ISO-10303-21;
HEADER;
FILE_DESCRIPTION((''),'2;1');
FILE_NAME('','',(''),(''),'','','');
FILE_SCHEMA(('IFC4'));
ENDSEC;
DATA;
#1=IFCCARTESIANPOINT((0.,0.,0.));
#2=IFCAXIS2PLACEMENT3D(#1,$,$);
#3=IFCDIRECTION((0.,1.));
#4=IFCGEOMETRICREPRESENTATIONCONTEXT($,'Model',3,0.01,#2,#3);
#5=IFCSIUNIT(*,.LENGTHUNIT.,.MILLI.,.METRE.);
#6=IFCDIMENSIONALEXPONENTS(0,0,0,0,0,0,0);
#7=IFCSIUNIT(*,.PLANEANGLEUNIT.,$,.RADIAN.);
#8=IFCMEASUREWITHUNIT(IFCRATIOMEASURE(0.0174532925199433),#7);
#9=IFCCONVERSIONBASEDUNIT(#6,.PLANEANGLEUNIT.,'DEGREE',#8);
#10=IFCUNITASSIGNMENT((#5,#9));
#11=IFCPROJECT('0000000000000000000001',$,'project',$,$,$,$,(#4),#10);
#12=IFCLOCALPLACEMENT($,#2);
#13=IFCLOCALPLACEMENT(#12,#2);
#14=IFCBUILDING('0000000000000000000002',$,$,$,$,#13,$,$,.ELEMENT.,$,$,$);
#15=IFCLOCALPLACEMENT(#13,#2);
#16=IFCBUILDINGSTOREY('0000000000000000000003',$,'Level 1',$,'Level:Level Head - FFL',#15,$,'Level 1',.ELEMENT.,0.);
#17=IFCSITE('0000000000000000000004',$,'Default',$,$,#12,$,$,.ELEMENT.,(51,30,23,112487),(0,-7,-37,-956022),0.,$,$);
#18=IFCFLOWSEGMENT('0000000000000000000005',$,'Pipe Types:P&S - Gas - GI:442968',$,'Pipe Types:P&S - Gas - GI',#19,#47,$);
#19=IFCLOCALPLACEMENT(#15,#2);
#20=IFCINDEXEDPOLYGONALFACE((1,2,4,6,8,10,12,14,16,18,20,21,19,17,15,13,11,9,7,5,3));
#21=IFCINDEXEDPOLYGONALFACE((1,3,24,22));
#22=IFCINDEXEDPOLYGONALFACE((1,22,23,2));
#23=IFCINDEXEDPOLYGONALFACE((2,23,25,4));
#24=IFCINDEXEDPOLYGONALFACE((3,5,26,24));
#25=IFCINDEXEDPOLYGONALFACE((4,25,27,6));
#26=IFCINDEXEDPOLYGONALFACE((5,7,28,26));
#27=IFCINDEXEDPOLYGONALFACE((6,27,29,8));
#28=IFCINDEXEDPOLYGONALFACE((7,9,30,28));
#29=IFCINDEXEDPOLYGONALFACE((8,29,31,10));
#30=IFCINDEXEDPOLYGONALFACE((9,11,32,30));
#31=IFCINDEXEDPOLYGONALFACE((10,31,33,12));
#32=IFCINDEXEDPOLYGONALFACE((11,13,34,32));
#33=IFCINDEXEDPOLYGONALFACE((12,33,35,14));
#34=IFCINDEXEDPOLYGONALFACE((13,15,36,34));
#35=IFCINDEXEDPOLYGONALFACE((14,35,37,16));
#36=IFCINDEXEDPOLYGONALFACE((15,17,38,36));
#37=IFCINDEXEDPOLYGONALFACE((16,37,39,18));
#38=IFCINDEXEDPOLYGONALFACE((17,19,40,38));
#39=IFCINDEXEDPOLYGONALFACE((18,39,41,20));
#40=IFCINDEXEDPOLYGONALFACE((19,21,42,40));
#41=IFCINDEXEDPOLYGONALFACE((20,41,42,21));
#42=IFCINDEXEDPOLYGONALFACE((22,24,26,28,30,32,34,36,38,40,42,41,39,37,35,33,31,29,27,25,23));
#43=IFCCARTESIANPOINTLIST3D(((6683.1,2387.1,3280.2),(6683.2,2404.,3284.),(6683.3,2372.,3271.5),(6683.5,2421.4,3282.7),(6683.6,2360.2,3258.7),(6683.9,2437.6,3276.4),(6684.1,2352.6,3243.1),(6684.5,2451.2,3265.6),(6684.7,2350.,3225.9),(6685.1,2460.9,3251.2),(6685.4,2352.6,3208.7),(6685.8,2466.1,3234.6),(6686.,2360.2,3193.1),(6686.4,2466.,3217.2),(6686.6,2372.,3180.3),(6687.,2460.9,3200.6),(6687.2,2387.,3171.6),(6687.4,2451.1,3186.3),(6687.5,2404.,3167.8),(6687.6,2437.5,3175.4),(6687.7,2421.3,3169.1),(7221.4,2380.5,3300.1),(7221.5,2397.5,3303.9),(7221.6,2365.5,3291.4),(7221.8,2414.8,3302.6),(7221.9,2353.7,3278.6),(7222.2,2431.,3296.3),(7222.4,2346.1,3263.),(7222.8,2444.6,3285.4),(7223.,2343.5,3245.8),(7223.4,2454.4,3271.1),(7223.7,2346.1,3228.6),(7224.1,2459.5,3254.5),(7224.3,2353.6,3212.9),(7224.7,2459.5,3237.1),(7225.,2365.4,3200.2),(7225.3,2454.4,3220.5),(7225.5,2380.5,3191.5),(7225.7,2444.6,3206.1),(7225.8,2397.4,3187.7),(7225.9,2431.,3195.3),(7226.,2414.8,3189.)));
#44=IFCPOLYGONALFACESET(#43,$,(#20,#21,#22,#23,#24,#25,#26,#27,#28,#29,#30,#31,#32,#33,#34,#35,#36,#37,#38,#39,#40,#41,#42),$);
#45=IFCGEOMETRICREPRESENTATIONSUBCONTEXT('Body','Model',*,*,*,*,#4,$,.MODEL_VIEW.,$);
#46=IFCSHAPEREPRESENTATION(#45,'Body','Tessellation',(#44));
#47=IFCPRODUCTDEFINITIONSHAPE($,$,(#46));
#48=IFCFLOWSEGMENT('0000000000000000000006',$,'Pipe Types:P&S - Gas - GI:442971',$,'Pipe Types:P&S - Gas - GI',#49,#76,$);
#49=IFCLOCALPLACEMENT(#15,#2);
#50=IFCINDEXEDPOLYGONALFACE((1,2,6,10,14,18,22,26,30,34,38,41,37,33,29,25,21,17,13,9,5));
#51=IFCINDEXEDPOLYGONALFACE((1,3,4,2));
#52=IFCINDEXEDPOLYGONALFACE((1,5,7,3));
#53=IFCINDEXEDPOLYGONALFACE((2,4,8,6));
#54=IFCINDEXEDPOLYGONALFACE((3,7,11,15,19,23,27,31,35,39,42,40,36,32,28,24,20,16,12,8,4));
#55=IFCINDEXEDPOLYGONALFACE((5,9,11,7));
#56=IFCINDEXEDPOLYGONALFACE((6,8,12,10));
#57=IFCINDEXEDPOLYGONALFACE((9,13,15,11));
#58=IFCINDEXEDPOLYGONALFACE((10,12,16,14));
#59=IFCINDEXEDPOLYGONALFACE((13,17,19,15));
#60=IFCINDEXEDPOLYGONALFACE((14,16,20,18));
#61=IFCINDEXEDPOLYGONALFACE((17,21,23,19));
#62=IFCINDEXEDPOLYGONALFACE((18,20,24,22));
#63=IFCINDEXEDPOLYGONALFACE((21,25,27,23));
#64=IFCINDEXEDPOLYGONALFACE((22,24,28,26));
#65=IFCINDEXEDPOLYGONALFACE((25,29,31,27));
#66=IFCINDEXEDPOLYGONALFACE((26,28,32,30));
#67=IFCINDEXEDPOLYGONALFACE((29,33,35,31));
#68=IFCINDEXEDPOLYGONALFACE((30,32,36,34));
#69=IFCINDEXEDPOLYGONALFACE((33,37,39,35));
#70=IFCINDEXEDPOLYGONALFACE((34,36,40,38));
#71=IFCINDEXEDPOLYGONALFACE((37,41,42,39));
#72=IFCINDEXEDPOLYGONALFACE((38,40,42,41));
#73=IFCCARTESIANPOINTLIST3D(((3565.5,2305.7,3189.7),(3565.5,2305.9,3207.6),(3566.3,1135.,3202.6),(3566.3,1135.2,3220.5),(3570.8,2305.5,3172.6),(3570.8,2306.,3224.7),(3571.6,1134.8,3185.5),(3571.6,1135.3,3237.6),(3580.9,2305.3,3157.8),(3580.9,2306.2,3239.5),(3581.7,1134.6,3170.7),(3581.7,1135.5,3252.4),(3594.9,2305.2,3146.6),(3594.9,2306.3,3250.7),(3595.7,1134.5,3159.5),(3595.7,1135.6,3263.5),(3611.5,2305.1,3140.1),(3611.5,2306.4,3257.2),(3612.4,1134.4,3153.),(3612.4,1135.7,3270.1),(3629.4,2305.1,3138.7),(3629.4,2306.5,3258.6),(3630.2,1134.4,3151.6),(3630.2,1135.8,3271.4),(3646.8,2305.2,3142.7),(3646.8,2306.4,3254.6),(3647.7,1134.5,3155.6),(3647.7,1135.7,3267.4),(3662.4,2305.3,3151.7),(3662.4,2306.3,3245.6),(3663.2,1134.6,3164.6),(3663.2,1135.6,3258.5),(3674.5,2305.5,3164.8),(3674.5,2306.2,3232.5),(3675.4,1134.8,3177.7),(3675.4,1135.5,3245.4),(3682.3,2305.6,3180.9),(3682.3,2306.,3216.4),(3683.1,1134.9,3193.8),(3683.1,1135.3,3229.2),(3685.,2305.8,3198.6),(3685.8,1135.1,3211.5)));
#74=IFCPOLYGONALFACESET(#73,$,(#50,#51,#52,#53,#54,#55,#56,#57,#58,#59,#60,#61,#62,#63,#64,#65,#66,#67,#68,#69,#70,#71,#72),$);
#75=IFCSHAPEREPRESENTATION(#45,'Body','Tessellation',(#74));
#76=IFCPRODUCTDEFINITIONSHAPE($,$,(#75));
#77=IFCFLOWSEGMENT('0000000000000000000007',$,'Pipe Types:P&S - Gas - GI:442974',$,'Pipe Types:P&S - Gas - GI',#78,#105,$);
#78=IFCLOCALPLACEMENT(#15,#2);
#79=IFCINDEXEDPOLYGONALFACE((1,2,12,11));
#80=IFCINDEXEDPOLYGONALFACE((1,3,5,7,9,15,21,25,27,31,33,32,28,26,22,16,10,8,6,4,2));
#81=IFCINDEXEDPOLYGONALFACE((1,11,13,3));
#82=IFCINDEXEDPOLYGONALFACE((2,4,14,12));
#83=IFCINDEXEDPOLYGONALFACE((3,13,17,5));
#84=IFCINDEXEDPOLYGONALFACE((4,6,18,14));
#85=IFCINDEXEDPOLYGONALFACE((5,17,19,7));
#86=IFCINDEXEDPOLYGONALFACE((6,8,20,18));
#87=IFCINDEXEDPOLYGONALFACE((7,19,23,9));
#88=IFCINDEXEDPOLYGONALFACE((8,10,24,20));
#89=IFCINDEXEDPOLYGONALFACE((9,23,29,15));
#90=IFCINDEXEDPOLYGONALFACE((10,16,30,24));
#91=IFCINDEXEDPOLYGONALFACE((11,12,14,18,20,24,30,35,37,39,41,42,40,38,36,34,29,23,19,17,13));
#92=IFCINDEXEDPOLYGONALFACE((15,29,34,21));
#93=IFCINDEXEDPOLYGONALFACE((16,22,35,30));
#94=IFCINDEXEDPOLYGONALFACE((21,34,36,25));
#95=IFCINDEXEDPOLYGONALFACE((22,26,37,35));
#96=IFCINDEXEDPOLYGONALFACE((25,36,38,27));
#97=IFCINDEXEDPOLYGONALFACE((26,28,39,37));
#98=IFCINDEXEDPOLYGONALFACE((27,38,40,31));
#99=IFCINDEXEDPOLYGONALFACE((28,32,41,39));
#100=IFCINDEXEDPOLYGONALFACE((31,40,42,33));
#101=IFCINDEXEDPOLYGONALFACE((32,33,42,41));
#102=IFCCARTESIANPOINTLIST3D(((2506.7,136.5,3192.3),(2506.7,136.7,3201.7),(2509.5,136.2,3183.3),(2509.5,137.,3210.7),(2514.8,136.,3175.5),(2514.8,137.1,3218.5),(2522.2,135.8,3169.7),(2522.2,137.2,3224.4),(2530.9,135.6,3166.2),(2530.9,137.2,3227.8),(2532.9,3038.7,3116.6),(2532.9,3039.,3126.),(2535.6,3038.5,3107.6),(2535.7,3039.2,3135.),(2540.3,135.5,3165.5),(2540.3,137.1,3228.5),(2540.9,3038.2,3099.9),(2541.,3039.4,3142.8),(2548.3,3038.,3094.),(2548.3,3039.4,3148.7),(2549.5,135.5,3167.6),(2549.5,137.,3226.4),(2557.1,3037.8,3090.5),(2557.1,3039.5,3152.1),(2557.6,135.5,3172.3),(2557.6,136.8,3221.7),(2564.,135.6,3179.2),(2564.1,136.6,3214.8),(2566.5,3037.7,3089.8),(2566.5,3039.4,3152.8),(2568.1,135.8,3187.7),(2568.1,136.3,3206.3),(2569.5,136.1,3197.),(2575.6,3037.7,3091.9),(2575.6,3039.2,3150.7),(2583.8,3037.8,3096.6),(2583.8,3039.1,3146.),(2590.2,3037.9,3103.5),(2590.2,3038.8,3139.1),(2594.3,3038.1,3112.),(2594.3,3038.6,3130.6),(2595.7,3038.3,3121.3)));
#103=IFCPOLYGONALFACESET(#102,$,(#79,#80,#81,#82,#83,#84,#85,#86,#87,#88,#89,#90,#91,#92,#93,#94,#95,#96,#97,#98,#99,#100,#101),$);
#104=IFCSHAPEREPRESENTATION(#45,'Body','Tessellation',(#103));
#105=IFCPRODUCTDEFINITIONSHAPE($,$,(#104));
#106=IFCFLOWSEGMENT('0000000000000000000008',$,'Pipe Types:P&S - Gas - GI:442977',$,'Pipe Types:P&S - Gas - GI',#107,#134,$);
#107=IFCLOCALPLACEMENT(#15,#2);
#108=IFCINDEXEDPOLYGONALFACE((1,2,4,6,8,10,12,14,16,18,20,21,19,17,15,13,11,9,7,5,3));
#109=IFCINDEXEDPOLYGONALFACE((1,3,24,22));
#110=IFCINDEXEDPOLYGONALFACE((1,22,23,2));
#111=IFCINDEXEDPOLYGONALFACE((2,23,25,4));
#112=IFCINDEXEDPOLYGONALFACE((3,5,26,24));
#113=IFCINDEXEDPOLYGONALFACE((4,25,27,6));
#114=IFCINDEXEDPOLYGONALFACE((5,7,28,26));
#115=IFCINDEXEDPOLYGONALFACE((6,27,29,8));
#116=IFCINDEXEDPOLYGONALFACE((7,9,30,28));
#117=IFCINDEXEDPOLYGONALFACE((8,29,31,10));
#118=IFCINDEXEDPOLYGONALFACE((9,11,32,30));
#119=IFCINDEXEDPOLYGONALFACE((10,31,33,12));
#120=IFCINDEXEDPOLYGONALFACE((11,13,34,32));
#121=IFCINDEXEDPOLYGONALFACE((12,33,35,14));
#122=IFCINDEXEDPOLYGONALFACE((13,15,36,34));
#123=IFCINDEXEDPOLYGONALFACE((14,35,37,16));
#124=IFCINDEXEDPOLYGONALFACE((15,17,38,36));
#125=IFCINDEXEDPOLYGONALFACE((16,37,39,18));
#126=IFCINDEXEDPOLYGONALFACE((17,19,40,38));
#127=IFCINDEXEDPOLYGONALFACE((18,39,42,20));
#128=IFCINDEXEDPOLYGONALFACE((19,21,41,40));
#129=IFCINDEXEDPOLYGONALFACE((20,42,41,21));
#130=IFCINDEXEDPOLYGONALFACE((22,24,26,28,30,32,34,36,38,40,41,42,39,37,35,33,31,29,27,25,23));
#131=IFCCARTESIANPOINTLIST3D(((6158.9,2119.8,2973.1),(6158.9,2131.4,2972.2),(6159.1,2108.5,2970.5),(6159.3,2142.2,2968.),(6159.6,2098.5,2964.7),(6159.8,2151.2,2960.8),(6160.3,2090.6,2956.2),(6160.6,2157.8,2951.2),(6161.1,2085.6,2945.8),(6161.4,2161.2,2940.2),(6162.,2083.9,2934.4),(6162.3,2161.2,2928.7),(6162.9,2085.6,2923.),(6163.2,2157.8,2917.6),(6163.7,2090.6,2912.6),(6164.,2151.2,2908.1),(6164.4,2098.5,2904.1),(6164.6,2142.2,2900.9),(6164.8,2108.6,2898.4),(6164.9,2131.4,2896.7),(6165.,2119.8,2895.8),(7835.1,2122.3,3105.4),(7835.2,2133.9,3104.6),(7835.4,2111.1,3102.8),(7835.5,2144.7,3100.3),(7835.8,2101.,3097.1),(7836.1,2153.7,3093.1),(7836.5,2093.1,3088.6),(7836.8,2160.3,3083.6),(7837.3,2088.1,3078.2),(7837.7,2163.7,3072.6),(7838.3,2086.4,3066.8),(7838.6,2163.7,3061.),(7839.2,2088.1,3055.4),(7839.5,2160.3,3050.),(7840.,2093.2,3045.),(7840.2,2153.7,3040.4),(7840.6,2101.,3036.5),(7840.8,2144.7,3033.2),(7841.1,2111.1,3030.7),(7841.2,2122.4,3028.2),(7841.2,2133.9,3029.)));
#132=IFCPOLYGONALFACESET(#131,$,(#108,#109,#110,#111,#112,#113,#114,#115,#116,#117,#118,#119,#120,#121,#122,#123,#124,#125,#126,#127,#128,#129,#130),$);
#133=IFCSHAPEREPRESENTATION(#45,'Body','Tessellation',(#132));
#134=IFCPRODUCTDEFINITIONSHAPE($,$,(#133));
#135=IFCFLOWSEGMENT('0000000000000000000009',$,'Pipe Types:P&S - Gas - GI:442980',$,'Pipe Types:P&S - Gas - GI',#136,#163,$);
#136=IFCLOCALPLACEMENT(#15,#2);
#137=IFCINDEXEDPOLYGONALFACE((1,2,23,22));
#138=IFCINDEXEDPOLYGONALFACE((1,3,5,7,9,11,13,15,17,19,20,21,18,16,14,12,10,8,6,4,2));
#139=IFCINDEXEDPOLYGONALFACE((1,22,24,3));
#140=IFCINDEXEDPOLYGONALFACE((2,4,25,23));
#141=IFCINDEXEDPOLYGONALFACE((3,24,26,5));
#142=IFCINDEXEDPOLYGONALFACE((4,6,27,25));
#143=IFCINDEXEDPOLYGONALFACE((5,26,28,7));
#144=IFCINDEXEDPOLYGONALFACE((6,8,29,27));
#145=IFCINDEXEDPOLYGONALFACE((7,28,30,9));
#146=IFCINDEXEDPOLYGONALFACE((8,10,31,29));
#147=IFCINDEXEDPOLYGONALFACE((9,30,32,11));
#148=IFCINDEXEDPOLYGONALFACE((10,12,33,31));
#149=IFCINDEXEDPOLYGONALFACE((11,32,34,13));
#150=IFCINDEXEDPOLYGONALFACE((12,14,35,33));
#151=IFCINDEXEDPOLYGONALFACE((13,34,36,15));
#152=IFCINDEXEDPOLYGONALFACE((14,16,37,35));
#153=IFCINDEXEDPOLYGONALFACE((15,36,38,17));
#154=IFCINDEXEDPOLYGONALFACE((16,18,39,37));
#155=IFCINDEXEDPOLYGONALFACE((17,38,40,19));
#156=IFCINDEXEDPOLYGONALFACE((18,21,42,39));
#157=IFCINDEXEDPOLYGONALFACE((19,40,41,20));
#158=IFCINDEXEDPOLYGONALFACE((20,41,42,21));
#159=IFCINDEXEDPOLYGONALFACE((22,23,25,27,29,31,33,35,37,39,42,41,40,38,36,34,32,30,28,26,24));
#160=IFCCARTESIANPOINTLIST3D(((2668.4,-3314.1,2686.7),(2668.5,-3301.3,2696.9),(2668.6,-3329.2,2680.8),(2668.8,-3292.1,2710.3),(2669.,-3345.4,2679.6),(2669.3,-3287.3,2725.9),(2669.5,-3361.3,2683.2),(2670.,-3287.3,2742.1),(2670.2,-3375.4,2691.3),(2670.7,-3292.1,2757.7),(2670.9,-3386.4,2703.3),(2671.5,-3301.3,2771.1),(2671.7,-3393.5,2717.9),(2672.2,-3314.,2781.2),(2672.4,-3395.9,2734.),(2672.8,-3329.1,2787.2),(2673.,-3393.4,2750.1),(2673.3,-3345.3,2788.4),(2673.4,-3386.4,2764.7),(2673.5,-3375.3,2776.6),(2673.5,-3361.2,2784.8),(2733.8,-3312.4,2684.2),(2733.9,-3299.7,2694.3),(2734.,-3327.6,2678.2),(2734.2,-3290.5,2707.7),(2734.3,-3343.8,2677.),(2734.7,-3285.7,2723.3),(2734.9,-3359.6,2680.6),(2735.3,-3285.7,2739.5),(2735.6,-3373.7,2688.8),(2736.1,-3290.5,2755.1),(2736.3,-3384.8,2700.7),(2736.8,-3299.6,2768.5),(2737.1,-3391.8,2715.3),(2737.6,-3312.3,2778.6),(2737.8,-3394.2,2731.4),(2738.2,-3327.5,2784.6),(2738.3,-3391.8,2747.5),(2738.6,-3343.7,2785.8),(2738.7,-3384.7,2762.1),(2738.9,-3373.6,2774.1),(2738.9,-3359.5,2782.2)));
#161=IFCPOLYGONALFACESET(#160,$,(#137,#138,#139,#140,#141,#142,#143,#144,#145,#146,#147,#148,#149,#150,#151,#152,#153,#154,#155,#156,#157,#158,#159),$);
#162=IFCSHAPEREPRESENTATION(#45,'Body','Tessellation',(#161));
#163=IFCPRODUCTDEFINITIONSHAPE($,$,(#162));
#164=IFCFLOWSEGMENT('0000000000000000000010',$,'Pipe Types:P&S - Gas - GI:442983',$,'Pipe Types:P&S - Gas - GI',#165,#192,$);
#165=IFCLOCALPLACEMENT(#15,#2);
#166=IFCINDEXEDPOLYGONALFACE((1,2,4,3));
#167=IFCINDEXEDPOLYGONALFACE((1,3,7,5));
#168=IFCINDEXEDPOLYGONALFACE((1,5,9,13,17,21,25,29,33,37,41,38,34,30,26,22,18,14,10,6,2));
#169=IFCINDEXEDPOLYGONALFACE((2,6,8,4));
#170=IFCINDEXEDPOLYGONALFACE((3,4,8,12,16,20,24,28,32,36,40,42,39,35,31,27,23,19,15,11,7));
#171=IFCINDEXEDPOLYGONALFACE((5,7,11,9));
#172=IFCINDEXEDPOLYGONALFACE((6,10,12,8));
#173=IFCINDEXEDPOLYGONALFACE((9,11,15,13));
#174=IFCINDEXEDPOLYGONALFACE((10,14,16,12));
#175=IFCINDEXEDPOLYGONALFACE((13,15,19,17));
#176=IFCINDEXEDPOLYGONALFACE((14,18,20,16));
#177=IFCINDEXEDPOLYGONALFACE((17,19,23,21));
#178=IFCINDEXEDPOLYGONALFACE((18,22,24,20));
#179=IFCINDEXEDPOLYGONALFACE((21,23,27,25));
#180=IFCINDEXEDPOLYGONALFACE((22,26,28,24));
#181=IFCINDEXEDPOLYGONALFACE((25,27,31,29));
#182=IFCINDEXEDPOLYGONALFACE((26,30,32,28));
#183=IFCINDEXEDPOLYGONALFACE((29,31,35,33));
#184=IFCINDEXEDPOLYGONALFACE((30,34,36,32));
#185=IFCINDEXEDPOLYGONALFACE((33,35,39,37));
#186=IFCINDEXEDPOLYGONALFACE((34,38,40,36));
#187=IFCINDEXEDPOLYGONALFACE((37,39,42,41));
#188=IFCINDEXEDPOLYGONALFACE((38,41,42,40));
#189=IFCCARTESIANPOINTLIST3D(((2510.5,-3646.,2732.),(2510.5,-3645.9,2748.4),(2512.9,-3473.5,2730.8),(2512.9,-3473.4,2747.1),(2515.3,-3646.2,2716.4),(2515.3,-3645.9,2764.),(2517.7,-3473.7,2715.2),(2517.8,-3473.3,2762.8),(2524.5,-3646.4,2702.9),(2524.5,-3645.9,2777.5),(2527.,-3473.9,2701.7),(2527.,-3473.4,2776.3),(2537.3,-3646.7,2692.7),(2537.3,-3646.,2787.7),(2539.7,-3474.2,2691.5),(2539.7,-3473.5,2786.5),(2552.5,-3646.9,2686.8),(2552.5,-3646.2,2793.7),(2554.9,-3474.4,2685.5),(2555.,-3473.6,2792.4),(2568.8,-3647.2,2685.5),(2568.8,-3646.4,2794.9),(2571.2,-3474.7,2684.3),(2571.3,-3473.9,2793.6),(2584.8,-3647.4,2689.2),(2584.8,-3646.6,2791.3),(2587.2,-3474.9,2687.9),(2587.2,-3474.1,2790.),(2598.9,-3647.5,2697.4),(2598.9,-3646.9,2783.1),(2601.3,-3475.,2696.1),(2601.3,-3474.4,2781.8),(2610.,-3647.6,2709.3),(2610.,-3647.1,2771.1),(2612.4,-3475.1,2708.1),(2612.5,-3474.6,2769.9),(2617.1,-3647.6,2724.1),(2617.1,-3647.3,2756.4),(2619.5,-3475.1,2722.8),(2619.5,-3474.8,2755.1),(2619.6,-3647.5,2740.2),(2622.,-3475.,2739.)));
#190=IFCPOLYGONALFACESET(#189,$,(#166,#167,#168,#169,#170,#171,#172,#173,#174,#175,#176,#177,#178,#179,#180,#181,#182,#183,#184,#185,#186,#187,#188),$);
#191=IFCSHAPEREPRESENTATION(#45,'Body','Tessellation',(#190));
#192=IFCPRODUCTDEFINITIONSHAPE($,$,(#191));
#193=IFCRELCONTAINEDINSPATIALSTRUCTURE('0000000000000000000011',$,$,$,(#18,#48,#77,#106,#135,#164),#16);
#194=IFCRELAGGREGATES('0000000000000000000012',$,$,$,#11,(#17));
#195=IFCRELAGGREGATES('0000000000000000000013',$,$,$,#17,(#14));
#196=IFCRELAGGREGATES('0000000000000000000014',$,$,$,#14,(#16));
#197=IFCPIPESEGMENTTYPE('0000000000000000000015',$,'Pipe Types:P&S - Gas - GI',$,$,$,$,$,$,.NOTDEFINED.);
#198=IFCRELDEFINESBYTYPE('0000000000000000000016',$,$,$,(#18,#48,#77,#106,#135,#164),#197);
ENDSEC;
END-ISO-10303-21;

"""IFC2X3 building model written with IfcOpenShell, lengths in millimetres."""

from ifc_helpers import new_model, entity, si_unit, converted_unit, direction, frame, frame_2d, origin, origin_2d_with_axis, place, context, subcontext, project, spatial, circle, extrude, type_object, element, save


model = new_model("IFC2X3")

# Units and contexts
model_context = context("Model", 3, precision=0.01, world=origin(), true_north=direction((0.0, 1.0)))
body_context = subcontext(model_context, "Body", "Model", "MODEL_VIEW")
ifc_project = project(units=[si_unit("LENGTHUNIT", "METRE", prefix="MILLI"), converted_unit("PLANEANGLEUNIT", "DEGREE", entity("IfcRatioMeasure", 0.0174532925199433), si_unit("PLANEANGLEUNIT", "RADIAN"), dimensions=[0, 0, 0, 0, 0, 0, 0])], contexts=[model_context])

# Site, building, storey
site_placement = place(None, origin())
site = spatial("IfcSite", under=ifc_project, at=site_placement, Name="Default", CompositionType="ELEMENT", RefLatitude=(51, 30, 23, 112487), RefLongitude=(0, -7, -37, -956022), RefElevation=0.0)
building_placement = place(site_placement, origin())
building = spatial("IfcBuilding", under=site, at=building_placement, CompositionType="ELEMENT")
storey_placement = place(building_placement, origin())
storey = spatial("IfcBuildingStorey", under=building, at=storey_placement, Name="Level 1", ObjectType="Level:Level Head - FFL", LongName="Level 1", CompositionType="ELEMENT", Elevation=0.0)

# Flow segments
pipe_segment_type = type_object("IfcPipeSegmentType", Name="Pipe Types:P&S - Gas - GI", PredefinedType="NOTDEFINED")
flow_segment_1_placement = place(storey_placement, origin())
element("IfcFlowSegment", 1, at=flow_segment_1_placement, inside=storey, type_object=pipe_segment_type, Name="Pipe Types:P&S - Gas - GI:442968", ObjectType="Pipe Types:P&S - Gas - GI", context=body_context, shape_type="SweptSolid", body=[
    extrude(circle(Radius=58.3, at=origin_2d_with_axis()), frame((6685.4, 2408.4, 3225.9), z_axis=(0.999245, -0.01214, 0.036915), x_axis=(-0.012148, -0.999926, 0.0)), (0.0, 0.0, 1.0), 538.7),
])
flow_segment_2_placement = place(storey_placement, origin())
element("IfcFlowSegment", 2, at=flow_segment_2_placement, inside=storey, type_object=pipe_segment_type, Name="Pipe Types:P&S - Gas - GI:442971", ObjectType="Pipe Types:P&S - Gas - GI", context=body_context, shape_type="SweptSolid", body=[
    extrude(circle(Radius=60.1, at=origin_2d_with_axis()), frame((3624.9, 2305.8, 3198.6), z_axis=(0.000707, -0.999939, 0.010991), x_axis=(1.0, 0.000708, 0.0)), (0.0, 0.0, 1.0), 1170.8),
])
flow_segment_3_placement = place(storey_placement, origin())
element("IfcFlowSegment", 3, at=flow_segment_3_placement, inside=storey, type_object=pipe_segment_type, Name="Pipe Types:P&S - Gas - GI:442974", ObjectType="Pipe Types:P&S - Gas - GI", context=body_context, shape_type="SweptSolid", body=[
    extrude(circle(Radius=31.6, at=frame_2d((0.0, 0.0), x_axis=(1.0, 0.0))), frame((2538.0, 136.3, 3197.0), z_axis=(0.009008, 0.999619, -0.026073), x_axis=(0.999959, -0.009011, 0.0)), (0.0, 0.0, 1.0), 2903.3),
])
flow_segment_4_placement = place(storey_placement, origin())
element("IfcFlowSegment", 4, at=flow_segment_4_placement, inside=storey, type_object=pipe_segment_type, Name="Pipe Types:P&S - Gas - GI:442977", ObjectType="Pipe Types:P&S - Gas - GI", context=body_context, shape_type="SweptSolid", body=[
    extrude(circle(Radius=38.9, at=origin_2d_with_axis()), frame((6161.9, 2122.7, 2934.4), z_axis=(0.996896, 0.001489, 0.078717), x_axis=(0.001493, -0.999999, 0.0)), (0.0, 0.0, 1.0), 1681.5),
])
flow_segment_5_placement = place(storey_placement, origin())
element("IfcFlowSegment", 5, at=flow_segment_5_placement, inside=storey, type_object=pipe_segment_type, Name="Pipe Types:P&S - Gas - GI:442980", ObjectType="Pipe Types:P&S - Gas - GI", context=body_context, shape_type="SweptSolid", body=[
    extrude(circle(Radius=54.6, at=frame_2d((0.0, 0.0), x_axis=(1.0, 0.0))), frame((2736.4, -3339.6, 2731.4), z_axis=(-0.998901, -0.025206, 0.03951), x_axis=(0.025226, -0.999682, 0.0)), (0.0, 0.0, 1.0), 65.5),
])
flow_segment_6_placement = place(storey_placement, origin())
element("IfcFlowSegment", 6, at=flow_segment_6_placement, inside=storey, type_object=pipe_segment_type, Name="Pipe Types:P&S - Gas - GI:442983", ObjectType="Pipe Types:P&S - Gas - GI", context=body_context, shape_type="SweptSolid", body=[
    extrude(circle(Radius=54.8, at=origin_2d_with_axis()), frame((2567.1, -3474.2, 2739.0), z_axis=(-0.01403, -0.999875, 0.007246), x_axis=(0.999902, -0.01403, 0.0)), (0.0, 0.0, 1.0), 172.5),
])

save(model, "model.ifc")
